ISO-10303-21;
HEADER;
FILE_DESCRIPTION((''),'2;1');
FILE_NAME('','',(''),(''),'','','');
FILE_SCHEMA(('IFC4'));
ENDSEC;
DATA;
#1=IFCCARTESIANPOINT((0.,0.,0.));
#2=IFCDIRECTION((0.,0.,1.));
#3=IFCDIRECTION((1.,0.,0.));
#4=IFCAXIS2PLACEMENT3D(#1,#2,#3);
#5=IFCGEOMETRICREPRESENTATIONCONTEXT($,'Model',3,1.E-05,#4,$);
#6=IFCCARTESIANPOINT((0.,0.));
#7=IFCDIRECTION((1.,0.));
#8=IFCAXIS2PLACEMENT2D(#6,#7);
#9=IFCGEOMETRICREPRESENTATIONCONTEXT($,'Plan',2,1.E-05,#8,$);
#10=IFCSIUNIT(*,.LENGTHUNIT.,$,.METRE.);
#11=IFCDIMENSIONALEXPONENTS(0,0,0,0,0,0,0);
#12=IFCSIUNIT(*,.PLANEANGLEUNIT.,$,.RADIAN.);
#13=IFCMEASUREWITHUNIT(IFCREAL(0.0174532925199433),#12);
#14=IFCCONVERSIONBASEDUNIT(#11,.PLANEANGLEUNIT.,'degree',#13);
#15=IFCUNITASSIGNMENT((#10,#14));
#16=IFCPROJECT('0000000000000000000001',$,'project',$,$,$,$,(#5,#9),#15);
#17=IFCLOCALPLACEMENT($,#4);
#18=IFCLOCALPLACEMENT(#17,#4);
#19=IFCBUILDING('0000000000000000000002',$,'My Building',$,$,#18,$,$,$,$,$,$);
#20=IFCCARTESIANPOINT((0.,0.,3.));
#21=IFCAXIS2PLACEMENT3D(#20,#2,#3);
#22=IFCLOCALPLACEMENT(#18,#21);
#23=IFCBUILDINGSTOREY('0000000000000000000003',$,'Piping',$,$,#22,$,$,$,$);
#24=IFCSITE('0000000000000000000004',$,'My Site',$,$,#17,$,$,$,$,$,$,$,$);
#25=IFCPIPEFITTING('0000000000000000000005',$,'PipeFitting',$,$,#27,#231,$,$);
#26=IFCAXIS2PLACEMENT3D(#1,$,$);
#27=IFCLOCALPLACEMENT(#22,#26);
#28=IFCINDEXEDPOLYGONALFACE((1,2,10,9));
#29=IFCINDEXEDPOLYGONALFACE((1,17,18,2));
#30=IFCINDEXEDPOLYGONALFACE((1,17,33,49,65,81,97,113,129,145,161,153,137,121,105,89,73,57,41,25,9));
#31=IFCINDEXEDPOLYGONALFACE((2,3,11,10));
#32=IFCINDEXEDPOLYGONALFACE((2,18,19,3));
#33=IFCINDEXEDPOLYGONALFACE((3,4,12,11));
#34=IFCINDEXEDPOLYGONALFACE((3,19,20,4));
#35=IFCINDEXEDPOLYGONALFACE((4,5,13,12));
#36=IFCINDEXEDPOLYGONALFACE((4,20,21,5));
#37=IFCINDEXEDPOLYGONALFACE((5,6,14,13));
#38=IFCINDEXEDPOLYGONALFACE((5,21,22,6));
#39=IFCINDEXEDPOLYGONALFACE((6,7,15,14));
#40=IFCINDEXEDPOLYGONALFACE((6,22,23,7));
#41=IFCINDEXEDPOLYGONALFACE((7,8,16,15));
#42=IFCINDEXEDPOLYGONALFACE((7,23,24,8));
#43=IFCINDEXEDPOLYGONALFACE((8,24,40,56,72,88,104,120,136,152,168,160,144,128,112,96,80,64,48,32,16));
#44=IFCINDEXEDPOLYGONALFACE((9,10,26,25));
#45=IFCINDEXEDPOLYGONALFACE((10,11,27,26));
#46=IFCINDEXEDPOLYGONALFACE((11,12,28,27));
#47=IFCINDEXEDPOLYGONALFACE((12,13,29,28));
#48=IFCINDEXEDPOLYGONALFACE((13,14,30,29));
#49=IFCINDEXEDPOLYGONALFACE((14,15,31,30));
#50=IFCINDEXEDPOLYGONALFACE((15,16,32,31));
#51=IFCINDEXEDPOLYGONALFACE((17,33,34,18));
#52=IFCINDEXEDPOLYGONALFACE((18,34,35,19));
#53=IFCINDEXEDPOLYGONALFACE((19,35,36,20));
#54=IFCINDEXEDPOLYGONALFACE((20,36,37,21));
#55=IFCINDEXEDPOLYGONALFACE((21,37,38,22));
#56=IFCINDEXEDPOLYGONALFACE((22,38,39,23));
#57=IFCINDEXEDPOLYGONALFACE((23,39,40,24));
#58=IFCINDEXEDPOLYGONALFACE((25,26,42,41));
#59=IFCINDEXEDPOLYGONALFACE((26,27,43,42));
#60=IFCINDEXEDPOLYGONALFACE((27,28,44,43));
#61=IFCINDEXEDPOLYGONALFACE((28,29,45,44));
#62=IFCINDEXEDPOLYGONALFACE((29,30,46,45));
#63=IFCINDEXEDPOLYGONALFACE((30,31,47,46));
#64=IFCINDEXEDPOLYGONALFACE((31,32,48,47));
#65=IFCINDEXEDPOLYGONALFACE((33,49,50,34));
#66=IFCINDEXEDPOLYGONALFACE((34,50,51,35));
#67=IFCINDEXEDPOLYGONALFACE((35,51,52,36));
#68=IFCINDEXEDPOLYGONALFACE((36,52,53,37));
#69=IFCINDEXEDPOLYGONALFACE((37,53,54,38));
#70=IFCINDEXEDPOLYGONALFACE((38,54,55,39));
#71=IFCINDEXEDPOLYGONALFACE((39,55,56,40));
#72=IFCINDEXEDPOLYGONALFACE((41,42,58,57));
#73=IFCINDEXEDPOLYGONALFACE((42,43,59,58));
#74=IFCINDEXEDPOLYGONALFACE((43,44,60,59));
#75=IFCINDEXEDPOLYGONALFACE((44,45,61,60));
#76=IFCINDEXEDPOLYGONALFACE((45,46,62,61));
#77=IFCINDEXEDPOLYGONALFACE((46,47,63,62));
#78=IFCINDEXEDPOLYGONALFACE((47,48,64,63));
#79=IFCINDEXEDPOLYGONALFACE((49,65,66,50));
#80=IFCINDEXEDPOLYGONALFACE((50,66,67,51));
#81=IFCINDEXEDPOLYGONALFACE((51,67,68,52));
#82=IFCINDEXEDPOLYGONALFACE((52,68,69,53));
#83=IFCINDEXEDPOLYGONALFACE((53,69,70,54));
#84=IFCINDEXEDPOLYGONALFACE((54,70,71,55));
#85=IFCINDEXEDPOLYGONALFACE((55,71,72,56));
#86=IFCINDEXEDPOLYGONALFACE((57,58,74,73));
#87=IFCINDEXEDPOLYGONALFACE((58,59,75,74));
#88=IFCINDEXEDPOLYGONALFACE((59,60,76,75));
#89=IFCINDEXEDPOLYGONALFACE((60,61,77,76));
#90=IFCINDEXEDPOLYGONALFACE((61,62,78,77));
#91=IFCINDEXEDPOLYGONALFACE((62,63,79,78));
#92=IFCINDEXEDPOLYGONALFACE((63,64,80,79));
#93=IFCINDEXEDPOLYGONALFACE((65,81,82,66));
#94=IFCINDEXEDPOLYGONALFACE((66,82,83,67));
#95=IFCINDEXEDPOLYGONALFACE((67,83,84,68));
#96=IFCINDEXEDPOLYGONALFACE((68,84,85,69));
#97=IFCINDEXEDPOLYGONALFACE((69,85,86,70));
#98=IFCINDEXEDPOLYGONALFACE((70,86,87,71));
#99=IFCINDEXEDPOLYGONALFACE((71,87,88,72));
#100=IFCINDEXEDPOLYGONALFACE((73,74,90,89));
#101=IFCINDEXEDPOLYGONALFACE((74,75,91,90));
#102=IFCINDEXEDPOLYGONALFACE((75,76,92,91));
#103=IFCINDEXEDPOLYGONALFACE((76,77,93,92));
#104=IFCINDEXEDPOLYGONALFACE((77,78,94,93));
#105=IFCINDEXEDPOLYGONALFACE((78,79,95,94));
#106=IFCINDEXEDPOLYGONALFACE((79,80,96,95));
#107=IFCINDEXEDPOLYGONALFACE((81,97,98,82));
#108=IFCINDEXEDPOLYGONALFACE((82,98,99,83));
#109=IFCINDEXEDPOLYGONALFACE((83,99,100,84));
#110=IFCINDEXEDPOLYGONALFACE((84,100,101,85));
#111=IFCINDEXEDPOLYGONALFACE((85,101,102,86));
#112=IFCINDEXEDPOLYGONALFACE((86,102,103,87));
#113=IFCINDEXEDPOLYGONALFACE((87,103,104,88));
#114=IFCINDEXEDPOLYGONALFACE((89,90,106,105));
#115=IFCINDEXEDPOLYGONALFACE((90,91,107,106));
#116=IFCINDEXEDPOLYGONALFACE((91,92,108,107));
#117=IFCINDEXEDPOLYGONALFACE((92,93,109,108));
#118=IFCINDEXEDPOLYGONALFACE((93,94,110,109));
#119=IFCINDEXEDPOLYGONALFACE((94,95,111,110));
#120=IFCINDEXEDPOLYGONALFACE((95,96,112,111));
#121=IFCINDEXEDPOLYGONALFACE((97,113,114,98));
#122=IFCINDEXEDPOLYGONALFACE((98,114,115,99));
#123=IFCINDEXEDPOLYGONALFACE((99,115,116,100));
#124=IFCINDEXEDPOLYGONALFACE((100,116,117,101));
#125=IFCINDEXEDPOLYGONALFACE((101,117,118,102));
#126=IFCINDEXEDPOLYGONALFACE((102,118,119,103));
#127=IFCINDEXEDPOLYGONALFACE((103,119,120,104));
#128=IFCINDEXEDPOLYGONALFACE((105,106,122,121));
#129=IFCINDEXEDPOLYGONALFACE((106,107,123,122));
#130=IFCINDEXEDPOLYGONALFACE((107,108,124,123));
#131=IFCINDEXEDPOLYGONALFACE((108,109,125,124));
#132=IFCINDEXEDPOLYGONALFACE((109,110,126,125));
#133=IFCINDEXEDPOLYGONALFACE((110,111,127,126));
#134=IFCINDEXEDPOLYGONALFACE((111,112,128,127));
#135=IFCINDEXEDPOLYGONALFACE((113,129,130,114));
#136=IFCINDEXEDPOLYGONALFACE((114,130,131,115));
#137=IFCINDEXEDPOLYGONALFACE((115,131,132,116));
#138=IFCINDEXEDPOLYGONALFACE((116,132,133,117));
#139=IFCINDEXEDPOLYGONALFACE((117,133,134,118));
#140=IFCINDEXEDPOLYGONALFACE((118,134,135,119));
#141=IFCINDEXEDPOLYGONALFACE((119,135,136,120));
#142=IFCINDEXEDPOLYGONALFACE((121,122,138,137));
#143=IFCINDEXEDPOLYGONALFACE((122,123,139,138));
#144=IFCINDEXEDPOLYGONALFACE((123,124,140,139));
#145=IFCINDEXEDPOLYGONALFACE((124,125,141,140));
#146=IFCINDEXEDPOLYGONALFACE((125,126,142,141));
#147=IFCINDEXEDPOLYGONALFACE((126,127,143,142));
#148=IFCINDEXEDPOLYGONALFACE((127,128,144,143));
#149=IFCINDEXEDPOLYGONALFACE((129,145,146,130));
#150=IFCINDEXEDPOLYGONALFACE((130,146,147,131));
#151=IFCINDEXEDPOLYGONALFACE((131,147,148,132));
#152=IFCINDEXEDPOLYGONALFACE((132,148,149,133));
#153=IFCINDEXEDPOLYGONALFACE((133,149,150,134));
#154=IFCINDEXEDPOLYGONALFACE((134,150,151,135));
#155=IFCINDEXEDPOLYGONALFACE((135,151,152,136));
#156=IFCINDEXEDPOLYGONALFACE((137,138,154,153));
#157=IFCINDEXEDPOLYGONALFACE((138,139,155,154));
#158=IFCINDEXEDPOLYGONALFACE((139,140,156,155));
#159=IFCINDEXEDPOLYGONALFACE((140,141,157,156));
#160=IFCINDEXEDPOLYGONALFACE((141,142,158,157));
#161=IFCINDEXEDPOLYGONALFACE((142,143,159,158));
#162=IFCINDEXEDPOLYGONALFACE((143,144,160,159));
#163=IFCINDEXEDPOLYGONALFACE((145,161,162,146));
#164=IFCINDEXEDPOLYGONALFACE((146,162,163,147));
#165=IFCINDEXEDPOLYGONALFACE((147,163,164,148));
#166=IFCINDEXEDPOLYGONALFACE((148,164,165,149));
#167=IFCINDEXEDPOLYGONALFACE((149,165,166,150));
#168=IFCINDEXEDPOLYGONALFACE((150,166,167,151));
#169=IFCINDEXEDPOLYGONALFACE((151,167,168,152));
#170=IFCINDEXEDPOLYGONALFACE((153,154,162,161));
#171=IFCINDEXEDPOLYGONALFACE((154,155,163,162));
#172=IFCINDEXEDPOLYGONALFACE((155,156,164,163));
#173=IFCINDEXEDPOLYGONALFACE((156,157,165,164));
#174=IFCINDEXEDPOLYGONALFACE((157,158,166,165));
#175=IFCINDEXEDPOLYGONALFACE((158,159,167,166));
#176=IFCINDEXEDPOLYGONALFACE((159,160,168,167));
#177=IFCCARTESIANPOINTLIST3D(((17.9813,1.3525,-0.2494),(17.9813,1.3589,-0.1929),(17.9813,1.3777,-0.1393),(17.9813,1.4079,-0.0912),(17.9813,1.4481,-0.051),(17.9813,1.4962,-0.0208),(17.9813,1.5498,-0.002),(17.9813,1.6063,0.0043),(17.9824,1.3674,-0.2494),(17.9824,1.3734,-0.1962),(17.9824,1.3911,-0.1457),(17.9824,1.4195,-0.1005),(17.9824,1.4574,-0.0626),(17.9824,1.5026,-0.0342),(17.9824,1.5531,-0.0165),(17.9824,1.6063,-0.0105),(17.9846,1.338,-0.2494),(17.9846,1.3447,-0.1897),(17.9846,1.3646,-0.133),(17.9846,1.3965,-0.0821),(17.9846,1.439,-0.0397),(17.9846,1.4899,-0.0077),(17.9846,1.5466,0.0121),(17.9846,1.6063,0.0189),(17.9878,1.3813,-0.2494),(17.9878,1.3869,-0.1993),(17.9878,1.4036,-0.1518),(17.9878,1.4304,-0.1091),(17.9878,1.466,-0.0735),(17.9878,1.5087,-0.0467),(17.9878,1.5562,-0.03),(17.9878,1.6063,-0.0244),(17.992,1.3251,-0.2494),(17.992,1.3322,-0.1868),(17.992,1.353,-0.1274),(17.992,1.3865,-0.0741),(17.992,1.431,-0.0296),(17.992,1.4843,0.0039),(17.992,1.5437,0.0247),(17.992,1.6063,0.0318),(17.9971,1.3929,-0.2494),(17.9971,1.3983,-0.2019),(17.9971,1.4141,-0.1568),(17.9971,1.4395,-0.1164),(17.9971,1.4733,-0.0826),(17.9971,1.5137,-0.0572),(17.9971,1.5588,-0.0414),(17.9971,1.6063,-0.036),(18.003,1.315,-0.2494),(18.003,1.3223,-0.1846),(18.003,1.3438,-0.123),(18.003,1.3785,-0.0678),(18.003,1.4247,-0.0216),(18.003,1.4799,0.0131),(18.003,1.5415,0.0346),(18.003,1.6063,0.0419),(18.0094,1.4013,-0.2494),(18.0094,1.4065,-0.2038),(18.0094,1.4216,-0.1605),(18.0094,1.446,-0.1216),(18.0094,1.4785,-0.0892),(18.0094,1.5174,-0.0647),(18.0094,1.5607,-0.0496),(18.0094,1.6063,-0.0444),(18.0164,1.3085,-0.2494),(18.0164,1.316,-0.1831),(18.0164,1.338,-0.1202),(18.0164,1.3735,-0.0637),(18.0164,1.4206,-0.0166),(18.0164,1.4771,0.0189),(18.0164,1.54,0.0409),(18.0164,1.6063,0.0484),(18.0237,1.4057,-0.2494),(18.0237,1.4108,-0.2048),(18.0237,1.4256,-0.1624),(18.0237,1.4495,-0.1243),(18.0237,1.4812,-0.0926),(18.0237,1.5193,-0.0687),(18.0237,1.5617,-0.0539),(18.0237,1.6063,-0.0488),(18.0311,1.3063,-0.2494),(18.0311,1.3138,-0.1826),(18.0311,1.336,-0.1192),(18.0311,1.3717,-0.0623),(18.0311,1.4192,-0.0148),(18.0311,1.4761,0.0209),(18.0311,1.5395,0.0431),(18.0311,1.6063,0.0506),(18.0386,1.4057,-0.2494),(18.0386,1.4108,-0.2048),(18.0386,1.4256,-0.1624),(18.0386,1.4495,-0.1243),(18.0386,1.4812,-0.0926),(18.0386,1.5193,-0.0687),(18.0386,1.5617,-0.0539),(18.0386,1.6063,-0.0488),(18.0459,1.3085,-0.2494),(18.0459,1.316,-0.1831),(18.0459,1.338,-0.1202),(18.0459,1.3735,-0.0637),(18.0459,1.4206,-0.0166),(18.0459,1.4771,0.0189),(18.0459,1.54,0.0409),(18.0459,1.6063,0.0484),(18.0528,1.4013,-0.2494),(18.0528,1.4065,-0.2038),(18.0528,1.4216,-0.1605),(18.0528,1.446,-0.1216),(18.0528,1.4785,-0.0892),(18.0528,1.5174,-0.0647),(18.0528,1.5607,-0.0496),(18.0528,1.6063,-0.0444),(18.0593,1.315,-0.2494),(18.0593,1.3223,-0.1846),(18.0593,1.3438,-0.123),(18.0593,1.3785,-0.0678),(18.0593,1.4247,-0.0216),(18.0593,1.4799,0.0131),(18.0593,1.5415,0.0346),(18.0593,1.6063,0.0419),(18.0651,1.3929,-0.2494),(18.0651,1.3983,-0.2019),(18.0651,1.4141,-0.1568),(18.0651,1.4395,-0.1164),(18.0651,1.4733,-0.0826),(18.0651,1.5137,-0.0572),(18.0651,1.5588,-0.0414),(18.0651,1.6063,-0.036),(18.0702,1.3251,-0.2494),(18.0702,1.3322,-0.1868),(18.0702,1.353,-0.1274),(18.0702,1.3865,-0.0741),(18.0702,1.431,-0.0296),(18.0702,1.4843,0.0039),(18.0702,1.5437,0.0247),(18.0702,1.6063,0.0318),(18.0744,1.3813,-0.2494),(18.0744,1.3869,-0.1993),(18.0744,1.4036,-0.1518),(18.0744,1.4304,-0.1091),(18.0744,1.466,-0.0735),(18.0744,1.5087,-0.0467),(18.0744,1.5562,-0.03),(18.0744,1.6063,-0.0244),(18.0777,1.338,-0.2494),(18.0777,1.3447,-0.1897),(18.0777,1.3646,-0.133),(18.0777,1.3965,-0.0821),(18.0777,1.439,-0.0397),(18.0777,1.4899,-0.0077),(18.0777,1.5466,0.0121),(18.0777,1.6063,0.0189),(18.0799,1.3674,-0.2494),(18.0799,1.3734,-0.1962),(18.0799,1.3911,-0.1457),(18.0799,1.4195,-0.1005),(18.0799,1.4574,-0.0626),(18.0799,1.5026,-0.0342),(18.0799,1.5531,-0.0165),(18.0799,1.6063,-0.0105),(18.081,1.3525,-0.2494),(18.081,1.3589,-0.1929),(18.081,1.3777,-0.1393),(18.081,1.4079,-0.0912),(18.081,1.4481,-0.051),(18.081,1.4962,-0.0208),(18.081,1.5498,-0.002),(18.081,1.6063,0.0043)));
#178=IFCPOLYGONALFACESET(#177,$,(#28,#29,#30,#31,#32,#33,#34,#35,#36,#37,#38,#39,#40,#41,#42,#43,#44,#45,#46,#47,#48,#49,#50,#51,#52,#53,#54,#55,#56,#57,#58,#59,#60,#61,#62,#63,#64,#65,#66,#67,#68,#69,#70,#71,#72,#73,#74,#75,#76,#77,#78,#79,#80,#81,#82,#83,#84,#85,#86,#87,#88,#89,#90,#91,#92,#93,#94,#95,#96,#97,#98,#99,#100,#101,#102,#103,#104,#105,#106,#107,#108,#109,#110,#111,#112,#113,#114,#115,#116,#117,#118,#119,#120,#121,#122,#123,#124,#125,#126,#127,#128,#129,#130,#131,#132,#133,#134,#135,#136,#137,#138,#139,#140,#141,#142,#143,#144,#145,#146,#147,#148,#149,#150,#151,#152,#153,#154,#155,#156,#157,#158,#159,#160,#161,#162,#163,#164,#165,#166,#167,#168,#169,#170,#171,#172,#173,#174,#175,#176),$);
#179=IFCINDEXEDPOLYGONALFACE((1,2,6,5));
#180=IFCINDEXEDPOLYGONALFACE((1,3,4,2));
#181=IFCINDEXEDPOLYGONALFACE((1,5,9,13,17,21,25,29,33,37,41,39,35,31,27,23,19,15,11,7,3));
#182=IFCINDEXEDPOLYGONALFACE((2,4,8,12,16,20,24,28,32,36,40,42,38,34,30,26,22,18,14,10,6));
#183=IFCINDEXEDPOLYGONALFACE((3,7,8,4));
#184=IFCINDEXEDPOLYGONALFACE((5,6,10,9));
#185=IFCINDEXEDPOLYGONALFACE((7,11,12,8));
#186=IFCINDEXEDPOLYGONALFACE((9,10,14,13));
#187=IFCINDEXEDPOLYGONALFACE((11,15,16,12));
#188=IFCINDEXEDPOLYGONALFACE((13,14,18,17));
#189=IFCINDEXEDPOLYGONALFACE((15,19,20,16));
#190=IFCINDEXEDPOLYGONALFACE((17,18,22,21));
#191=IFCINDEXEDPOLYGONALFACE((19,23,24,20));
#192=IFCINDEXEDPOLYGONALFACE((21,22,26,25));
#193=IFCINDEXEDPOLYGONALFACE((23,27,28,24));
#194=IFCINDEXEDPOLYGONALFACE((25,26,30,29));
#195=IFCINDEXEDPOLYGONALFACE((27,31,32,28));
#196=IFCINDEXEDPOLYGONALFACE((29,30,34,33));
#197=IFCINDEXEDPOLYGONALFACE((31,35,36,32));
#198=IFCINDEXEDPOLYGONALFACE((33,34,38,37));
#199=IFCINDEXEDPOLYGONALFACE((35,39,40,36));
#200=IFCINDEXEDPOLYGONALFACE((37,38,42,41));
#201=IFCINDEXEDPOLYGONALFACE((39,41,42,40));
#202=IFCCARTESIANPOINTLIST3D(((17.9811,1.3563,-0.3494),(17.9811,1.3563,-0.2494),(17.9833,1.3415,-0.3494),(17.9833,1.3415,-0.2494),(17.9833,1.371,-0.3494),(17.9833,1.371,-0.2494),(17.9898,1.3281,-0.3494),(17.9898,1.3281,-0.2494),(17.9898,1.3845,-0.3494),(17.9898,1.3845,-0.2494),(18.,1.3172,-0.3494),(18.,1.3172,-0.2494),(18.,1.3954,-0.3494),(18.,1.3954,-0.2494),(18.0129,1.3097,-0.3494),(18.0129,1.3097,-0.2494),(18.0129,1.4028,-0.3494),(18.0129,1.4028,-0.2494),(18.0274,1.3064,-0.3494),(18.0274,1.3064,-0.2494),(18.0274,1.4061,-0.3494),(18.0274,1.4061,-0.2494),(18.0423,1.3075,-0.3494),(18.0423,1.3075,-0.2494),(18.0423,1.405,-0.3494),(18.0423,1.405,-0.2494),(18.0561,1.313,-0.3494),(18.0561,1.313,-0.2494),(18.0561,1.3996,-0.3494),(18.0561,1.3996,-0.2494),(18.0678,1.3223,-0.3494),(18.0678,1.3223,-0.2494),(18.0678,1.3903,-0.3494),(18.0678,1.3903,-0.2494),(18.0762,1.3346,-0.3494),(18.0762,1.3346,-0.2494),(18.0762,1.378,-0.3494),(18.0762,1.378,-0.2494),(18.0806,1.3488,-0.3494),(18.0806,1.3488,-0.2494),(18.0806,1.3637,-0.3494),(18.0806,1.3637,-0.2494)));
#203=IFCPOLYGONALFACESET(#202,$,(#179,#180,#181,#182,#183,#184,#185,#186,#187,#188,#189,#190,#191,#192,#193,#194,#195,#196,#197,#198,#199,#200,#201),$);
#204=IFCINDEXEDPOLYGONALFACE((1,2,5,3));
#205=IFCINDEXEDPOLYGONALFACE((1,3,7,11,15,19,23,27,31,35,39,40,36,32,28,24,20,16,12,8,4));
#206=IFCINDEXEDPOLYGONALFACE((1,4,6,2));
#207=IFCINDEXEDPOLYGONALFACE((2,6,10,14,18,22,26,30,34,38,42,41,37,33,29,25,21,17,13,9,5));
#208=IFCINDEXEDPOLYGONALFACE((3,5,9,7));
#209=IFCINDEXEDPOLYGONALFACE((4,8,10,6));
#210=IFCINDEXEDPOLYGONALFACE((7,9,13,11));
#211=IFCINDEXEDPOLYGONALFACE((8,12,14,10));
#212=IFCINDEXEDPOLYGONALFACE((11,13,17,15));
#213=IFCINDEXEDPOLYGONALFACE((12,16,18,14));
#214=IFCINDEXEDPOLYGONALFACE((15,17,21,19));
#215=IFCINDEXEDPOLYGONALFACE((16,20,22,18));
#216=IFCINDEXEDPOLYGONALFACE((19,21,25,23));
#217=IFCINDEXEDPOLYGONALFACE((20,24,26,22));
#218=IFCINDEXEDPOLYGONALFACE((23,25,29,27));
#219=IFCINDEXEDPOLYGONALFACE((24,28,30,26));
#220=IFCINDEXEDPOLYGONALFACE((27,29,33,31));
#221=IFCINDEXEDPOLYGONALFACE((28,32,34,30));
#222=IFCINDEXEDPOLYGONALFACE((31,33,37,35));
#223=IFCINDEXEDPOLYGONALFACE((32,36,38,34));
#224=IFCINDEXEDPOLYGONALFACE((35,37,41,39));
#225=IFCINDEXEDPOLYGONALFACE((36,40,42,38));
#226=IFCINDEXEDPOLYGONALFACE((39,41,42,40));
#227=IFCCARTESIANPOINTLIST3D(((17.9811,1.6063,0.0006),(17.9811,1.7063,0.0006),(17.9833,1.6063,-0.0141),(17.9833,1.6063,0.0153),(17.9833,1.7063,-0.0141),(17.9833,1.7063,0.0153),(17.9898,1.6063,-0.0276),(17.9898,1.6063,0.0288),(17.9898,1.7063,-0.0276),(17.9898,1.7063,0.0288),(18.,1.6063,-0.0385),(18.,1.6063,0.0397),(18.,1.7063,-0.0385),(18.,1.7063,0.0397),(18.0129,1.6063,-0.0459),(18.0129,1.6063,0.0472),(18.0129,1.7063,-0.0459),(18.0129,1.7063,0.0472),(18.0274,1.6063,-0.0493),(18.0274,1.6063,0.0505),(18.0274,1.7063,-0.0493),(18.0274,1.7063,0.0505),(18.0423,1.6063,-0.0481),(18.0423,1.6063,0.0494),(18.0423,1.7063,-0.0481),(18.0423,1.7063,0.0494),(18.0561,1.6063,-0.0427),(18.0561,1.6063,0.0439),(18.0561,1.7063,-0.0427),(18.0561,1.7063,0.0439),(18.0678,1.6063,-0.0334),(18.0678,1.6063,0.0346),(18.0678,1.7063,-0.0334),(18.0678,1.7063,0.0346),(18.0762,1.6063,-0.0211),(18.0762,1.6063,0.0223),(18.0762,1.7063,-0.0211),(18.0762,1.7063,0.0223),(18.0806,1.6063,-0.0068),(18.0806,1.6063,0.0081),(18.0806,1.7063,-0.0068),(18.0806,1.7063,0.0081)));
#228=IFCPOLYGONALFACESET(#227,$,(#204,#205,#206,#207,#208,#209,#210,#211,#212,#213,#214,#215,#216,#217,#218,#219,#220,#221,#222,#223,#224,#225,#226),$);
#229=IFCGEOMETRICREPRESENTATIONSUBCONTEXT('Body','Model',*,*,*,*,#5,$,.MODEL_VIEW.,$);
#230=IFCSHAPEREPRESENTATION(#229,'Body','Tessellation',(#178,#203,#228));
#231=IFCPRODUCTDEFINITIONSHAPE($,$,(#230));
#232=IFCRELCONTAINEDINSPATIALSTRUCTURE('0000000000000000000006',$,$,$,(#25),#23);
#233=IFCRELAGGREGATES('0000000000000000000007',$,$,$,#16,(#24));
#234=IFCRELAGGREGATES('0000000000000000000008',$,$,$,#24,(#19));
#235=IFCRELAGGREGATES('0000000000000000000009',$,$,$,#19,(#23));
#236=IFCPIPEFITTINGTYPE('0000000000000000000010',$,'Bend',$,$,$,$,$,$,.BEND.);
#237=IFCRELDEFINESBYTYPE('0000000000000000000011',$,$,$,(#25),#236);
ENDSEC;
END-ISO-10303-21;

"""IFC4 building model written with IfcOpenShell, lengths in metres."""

from ifc_helpers import new_model, entity, si_unit, converted_unit, frame, origin_with_axes, origin_2d_with_axis, place, context, subcontext, project, spatial, circle, extrude, source, transform, mapped, type_object, type_shapes, element, save


model = new_model("IFC4")

# Units and contexts
model_context = context("Model", 3, precision=1e-05, world=origin_with_axes())
plan_context = context("Plan", 2, precision=1e-05, world=origin_2d_with_axis())
body_context = subcontext(model_context, "Body", "Model", "MODEL_VIEW")
ifc_project = project(units=[si_unit("LENGTHUNIT", "METRE"), converted_unit("PLANEANGLEUNIT", "degree", entity("IfcReal", 0.0174532925199433), si_unit("PLANEANGLEUNIT", "RADIAN"), dimensions=[0, 0, 0, 0, 0, 0, 0])], contexts=[model_context, plan_context])

# Site, building, storey
site_placement = place(None, origin_with_axes())
site = spatial("IfcSite", under=ifc_project, at=site_placement, Name="My Site")
building_placement = place(site_placement, origin_with_axes())
building = spatial("IfcBuilding", under=site, at=building_placement, Name="My Building")
storey_placement = place(building_placement, frame((0.0, 0.0, 3.0), z_axis=(0.0, 0.0, 1.0), x_axis=(1.0, 0.0, 0.0)))
storey = spatial("IfcBuildingStorey", under=building, at=storey_placement, Name="Piping")

# Pipe fitting
pipe_fitting_type_1 = type_object("IfcPipeFittingType", Name="Bend", PredefinedType="BEND")
shared_shape = source(origin_with_axes(), body_context, "Body", "SolidModel", [
    entity("IfcSweptDiskSolid", entity("IfcIndexedPolyCurve", entity("IfcCartesianPointList3D", [[0.0, 0.0, -0.1], [0.0, 0.0732, -0.2768], [0.0, 0.25, -0.35]]), [entity("IfcArcIndex", [1, 2, 3])]), 0.05),
    extrude(circle(Radius=0.05), origin_with_axes(), (0.0, 0.0, -1.0), 0.1),
    extrude(circle(Radius=0.05), frame((0.0, 0.25, -0.35), z_axis=(0.0, 1.0, 0.0), x_axis=(1.0, 0.0, 0.0)), (0.0, 0.0, 1.0), 0.1),
])
type_shapes(pipe_fitting_type_1, [shared_shape])
for number, where, z_axis, x_axis, name in (
    (1, (18.0311, 1.3563, -0.3494), (0.0, 0.0, -1.0), (-1.0, 0.0, 0.0), "PipeFitting"),
):
    element("IfcPipeFitting", number, at=place(storey_placement, frame(where, z_axis=z_axis, x_axis=x_axis)), inside=storey, type_object=pipe_fitting_type_1, Name=name, context=body_context, shape_type="MappedRepresentation", body=[
        mapped(shared_shape, transform((0.0, 0.0, 0.0), x_axis=(1.0, 0.0, 0.0), y_axis=(0.0, 1.0, 0.0), z_axis=(0.0, 0.0, 1.0), scale=1.0)),
    ])

save(model, "model.ifc")
